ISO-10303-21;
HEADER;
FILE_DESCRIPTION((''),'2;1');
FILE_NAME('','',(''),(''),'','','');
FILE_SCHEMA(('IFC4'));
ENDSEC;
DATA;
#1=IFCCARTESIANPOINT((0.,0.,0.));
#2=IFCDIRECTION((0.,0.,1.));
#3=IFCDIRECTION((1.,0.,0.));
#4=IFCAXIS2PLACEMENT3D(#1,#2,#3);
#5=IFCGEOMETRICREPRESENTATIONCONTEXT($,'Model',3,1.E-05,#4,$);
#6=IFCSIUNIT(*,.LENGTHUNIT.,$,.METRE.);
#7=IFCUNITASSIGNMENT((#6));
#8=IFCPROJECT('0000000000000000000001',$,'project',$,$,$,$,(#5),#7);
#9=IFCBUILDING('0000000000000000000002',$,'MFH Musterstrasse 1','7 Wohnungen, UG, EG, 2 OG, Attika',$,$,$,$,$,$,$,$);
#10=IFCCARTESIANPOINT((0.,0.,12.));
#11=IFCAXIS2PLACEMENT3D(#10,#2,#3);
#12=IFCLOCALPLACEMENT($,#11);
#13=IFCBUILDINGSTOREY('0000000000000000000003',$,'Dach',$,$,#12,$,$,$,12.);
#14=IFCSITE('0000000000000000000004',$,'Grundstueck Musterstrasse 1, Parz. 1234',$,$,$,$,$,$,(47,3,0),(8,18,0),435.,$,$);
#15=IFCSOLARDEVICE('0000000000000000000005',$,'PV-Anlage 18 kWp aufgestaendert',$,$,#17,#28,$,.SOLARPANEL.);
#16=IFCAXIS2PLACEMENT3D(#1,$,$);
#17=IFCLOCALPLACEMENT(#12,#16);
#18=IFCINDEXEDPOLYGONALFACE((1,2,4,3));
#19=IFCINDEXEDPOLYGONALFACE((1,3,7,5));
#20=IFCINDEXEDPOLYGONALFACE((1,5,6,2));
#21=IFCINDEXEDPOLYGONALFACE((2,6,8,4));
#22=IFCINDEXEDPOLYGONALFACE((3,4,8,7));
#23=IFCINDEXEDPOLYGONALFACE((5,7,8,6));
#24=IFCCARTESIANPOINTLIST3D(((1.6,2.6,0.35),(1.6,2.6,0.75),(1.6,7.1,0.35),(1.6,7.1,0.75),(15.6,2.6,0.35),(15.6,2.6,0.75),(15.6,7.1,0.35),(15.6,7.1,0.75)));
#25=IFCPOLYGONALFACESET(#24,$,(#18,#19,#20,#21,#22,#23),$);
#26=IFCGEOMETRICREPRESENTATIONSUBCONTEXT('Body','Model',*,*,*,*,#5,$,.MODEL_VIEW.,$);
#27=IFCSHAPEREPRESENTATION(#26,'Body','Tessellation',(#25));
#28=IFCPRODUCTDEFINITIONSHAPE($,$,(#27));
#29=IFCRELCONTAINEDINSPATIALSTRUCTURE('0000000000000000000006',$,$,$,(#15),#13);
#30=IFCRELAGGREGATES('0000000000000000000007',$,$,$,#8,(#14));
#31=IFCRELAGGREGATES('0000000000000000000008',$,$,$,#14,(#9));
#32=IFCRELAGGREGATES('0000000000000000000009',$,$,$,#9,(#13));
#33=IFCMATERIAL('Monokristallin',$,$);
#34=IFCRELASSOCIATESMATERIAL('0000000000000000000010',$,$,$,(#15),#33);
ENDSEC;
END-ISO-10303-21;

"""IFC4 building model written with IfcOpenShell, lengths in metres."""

from ifc_helpers import new_model, si_unit, frame, frame_2d, origin_with_axes, place, context, subcontext, project, spatial, rectangle, extrude, material, element, save


model = new_model("IFC4")

# Units and contexts
model_context = context("Model", 3, precision=1e-05, world=origin_with_axes())
body_context = subcontext(model_context, "Body", "Model", "MODEL_VIEW")
ifc_project = project(units=[si_unit("LENGTHUNIT", "METRE")], contexts=[model_context])

# Site, building, storey
site = spatial("IfcSite", under=ifc_project, Name="Grundstueck Musterstrasse 1, Parz. 1234", RefLatitude=(47, 3, 0), RefLongitude=(8, 18, 0), RefElevation=435.0)
building = spatial("IfcBuilding", under=site, Name="MFH Musterstrasse 1", Description="7 Wohnungen, UG, EG, 2 OG, Attika")
storey_placement = place(None, frame((0.0, 0.0, 12.0), z_axis=(0.0, 0.0, 1.0), x_axis=(1.0, 0.0, 0.0)))
storey = spatial("IfcBuildingStorey", under=building, at=storey_placement, Name="Dach", Elevation=12.0)

# Solar device
ifc_material_1 = material(Name="Monokristallin")
solar_device_placement = place(storey_placement, frame((1.6, 2.6, 0.35), z_axis=(0.0, 0.0, 1.0), x_axis=(1.0, 0.0, 0.0)))
element("IfcSolarDevice", 1, at=solar_device_placement, inside=storey, material=ifc_material_1, Name="PV-Anlage 18 kWp aufgestaendert", PredefinedType="SOLARPANEL", context=body_context, shape_type="SweptSolid", body=[
    extrude(rectangle(XDim=14.0, YDim=4.5, at=frame_2d((7.0, 2.25))), origin_with_axes(), (0.0, 0.0, 1.0), 0.4),
])

save(model, "model.ifc")
